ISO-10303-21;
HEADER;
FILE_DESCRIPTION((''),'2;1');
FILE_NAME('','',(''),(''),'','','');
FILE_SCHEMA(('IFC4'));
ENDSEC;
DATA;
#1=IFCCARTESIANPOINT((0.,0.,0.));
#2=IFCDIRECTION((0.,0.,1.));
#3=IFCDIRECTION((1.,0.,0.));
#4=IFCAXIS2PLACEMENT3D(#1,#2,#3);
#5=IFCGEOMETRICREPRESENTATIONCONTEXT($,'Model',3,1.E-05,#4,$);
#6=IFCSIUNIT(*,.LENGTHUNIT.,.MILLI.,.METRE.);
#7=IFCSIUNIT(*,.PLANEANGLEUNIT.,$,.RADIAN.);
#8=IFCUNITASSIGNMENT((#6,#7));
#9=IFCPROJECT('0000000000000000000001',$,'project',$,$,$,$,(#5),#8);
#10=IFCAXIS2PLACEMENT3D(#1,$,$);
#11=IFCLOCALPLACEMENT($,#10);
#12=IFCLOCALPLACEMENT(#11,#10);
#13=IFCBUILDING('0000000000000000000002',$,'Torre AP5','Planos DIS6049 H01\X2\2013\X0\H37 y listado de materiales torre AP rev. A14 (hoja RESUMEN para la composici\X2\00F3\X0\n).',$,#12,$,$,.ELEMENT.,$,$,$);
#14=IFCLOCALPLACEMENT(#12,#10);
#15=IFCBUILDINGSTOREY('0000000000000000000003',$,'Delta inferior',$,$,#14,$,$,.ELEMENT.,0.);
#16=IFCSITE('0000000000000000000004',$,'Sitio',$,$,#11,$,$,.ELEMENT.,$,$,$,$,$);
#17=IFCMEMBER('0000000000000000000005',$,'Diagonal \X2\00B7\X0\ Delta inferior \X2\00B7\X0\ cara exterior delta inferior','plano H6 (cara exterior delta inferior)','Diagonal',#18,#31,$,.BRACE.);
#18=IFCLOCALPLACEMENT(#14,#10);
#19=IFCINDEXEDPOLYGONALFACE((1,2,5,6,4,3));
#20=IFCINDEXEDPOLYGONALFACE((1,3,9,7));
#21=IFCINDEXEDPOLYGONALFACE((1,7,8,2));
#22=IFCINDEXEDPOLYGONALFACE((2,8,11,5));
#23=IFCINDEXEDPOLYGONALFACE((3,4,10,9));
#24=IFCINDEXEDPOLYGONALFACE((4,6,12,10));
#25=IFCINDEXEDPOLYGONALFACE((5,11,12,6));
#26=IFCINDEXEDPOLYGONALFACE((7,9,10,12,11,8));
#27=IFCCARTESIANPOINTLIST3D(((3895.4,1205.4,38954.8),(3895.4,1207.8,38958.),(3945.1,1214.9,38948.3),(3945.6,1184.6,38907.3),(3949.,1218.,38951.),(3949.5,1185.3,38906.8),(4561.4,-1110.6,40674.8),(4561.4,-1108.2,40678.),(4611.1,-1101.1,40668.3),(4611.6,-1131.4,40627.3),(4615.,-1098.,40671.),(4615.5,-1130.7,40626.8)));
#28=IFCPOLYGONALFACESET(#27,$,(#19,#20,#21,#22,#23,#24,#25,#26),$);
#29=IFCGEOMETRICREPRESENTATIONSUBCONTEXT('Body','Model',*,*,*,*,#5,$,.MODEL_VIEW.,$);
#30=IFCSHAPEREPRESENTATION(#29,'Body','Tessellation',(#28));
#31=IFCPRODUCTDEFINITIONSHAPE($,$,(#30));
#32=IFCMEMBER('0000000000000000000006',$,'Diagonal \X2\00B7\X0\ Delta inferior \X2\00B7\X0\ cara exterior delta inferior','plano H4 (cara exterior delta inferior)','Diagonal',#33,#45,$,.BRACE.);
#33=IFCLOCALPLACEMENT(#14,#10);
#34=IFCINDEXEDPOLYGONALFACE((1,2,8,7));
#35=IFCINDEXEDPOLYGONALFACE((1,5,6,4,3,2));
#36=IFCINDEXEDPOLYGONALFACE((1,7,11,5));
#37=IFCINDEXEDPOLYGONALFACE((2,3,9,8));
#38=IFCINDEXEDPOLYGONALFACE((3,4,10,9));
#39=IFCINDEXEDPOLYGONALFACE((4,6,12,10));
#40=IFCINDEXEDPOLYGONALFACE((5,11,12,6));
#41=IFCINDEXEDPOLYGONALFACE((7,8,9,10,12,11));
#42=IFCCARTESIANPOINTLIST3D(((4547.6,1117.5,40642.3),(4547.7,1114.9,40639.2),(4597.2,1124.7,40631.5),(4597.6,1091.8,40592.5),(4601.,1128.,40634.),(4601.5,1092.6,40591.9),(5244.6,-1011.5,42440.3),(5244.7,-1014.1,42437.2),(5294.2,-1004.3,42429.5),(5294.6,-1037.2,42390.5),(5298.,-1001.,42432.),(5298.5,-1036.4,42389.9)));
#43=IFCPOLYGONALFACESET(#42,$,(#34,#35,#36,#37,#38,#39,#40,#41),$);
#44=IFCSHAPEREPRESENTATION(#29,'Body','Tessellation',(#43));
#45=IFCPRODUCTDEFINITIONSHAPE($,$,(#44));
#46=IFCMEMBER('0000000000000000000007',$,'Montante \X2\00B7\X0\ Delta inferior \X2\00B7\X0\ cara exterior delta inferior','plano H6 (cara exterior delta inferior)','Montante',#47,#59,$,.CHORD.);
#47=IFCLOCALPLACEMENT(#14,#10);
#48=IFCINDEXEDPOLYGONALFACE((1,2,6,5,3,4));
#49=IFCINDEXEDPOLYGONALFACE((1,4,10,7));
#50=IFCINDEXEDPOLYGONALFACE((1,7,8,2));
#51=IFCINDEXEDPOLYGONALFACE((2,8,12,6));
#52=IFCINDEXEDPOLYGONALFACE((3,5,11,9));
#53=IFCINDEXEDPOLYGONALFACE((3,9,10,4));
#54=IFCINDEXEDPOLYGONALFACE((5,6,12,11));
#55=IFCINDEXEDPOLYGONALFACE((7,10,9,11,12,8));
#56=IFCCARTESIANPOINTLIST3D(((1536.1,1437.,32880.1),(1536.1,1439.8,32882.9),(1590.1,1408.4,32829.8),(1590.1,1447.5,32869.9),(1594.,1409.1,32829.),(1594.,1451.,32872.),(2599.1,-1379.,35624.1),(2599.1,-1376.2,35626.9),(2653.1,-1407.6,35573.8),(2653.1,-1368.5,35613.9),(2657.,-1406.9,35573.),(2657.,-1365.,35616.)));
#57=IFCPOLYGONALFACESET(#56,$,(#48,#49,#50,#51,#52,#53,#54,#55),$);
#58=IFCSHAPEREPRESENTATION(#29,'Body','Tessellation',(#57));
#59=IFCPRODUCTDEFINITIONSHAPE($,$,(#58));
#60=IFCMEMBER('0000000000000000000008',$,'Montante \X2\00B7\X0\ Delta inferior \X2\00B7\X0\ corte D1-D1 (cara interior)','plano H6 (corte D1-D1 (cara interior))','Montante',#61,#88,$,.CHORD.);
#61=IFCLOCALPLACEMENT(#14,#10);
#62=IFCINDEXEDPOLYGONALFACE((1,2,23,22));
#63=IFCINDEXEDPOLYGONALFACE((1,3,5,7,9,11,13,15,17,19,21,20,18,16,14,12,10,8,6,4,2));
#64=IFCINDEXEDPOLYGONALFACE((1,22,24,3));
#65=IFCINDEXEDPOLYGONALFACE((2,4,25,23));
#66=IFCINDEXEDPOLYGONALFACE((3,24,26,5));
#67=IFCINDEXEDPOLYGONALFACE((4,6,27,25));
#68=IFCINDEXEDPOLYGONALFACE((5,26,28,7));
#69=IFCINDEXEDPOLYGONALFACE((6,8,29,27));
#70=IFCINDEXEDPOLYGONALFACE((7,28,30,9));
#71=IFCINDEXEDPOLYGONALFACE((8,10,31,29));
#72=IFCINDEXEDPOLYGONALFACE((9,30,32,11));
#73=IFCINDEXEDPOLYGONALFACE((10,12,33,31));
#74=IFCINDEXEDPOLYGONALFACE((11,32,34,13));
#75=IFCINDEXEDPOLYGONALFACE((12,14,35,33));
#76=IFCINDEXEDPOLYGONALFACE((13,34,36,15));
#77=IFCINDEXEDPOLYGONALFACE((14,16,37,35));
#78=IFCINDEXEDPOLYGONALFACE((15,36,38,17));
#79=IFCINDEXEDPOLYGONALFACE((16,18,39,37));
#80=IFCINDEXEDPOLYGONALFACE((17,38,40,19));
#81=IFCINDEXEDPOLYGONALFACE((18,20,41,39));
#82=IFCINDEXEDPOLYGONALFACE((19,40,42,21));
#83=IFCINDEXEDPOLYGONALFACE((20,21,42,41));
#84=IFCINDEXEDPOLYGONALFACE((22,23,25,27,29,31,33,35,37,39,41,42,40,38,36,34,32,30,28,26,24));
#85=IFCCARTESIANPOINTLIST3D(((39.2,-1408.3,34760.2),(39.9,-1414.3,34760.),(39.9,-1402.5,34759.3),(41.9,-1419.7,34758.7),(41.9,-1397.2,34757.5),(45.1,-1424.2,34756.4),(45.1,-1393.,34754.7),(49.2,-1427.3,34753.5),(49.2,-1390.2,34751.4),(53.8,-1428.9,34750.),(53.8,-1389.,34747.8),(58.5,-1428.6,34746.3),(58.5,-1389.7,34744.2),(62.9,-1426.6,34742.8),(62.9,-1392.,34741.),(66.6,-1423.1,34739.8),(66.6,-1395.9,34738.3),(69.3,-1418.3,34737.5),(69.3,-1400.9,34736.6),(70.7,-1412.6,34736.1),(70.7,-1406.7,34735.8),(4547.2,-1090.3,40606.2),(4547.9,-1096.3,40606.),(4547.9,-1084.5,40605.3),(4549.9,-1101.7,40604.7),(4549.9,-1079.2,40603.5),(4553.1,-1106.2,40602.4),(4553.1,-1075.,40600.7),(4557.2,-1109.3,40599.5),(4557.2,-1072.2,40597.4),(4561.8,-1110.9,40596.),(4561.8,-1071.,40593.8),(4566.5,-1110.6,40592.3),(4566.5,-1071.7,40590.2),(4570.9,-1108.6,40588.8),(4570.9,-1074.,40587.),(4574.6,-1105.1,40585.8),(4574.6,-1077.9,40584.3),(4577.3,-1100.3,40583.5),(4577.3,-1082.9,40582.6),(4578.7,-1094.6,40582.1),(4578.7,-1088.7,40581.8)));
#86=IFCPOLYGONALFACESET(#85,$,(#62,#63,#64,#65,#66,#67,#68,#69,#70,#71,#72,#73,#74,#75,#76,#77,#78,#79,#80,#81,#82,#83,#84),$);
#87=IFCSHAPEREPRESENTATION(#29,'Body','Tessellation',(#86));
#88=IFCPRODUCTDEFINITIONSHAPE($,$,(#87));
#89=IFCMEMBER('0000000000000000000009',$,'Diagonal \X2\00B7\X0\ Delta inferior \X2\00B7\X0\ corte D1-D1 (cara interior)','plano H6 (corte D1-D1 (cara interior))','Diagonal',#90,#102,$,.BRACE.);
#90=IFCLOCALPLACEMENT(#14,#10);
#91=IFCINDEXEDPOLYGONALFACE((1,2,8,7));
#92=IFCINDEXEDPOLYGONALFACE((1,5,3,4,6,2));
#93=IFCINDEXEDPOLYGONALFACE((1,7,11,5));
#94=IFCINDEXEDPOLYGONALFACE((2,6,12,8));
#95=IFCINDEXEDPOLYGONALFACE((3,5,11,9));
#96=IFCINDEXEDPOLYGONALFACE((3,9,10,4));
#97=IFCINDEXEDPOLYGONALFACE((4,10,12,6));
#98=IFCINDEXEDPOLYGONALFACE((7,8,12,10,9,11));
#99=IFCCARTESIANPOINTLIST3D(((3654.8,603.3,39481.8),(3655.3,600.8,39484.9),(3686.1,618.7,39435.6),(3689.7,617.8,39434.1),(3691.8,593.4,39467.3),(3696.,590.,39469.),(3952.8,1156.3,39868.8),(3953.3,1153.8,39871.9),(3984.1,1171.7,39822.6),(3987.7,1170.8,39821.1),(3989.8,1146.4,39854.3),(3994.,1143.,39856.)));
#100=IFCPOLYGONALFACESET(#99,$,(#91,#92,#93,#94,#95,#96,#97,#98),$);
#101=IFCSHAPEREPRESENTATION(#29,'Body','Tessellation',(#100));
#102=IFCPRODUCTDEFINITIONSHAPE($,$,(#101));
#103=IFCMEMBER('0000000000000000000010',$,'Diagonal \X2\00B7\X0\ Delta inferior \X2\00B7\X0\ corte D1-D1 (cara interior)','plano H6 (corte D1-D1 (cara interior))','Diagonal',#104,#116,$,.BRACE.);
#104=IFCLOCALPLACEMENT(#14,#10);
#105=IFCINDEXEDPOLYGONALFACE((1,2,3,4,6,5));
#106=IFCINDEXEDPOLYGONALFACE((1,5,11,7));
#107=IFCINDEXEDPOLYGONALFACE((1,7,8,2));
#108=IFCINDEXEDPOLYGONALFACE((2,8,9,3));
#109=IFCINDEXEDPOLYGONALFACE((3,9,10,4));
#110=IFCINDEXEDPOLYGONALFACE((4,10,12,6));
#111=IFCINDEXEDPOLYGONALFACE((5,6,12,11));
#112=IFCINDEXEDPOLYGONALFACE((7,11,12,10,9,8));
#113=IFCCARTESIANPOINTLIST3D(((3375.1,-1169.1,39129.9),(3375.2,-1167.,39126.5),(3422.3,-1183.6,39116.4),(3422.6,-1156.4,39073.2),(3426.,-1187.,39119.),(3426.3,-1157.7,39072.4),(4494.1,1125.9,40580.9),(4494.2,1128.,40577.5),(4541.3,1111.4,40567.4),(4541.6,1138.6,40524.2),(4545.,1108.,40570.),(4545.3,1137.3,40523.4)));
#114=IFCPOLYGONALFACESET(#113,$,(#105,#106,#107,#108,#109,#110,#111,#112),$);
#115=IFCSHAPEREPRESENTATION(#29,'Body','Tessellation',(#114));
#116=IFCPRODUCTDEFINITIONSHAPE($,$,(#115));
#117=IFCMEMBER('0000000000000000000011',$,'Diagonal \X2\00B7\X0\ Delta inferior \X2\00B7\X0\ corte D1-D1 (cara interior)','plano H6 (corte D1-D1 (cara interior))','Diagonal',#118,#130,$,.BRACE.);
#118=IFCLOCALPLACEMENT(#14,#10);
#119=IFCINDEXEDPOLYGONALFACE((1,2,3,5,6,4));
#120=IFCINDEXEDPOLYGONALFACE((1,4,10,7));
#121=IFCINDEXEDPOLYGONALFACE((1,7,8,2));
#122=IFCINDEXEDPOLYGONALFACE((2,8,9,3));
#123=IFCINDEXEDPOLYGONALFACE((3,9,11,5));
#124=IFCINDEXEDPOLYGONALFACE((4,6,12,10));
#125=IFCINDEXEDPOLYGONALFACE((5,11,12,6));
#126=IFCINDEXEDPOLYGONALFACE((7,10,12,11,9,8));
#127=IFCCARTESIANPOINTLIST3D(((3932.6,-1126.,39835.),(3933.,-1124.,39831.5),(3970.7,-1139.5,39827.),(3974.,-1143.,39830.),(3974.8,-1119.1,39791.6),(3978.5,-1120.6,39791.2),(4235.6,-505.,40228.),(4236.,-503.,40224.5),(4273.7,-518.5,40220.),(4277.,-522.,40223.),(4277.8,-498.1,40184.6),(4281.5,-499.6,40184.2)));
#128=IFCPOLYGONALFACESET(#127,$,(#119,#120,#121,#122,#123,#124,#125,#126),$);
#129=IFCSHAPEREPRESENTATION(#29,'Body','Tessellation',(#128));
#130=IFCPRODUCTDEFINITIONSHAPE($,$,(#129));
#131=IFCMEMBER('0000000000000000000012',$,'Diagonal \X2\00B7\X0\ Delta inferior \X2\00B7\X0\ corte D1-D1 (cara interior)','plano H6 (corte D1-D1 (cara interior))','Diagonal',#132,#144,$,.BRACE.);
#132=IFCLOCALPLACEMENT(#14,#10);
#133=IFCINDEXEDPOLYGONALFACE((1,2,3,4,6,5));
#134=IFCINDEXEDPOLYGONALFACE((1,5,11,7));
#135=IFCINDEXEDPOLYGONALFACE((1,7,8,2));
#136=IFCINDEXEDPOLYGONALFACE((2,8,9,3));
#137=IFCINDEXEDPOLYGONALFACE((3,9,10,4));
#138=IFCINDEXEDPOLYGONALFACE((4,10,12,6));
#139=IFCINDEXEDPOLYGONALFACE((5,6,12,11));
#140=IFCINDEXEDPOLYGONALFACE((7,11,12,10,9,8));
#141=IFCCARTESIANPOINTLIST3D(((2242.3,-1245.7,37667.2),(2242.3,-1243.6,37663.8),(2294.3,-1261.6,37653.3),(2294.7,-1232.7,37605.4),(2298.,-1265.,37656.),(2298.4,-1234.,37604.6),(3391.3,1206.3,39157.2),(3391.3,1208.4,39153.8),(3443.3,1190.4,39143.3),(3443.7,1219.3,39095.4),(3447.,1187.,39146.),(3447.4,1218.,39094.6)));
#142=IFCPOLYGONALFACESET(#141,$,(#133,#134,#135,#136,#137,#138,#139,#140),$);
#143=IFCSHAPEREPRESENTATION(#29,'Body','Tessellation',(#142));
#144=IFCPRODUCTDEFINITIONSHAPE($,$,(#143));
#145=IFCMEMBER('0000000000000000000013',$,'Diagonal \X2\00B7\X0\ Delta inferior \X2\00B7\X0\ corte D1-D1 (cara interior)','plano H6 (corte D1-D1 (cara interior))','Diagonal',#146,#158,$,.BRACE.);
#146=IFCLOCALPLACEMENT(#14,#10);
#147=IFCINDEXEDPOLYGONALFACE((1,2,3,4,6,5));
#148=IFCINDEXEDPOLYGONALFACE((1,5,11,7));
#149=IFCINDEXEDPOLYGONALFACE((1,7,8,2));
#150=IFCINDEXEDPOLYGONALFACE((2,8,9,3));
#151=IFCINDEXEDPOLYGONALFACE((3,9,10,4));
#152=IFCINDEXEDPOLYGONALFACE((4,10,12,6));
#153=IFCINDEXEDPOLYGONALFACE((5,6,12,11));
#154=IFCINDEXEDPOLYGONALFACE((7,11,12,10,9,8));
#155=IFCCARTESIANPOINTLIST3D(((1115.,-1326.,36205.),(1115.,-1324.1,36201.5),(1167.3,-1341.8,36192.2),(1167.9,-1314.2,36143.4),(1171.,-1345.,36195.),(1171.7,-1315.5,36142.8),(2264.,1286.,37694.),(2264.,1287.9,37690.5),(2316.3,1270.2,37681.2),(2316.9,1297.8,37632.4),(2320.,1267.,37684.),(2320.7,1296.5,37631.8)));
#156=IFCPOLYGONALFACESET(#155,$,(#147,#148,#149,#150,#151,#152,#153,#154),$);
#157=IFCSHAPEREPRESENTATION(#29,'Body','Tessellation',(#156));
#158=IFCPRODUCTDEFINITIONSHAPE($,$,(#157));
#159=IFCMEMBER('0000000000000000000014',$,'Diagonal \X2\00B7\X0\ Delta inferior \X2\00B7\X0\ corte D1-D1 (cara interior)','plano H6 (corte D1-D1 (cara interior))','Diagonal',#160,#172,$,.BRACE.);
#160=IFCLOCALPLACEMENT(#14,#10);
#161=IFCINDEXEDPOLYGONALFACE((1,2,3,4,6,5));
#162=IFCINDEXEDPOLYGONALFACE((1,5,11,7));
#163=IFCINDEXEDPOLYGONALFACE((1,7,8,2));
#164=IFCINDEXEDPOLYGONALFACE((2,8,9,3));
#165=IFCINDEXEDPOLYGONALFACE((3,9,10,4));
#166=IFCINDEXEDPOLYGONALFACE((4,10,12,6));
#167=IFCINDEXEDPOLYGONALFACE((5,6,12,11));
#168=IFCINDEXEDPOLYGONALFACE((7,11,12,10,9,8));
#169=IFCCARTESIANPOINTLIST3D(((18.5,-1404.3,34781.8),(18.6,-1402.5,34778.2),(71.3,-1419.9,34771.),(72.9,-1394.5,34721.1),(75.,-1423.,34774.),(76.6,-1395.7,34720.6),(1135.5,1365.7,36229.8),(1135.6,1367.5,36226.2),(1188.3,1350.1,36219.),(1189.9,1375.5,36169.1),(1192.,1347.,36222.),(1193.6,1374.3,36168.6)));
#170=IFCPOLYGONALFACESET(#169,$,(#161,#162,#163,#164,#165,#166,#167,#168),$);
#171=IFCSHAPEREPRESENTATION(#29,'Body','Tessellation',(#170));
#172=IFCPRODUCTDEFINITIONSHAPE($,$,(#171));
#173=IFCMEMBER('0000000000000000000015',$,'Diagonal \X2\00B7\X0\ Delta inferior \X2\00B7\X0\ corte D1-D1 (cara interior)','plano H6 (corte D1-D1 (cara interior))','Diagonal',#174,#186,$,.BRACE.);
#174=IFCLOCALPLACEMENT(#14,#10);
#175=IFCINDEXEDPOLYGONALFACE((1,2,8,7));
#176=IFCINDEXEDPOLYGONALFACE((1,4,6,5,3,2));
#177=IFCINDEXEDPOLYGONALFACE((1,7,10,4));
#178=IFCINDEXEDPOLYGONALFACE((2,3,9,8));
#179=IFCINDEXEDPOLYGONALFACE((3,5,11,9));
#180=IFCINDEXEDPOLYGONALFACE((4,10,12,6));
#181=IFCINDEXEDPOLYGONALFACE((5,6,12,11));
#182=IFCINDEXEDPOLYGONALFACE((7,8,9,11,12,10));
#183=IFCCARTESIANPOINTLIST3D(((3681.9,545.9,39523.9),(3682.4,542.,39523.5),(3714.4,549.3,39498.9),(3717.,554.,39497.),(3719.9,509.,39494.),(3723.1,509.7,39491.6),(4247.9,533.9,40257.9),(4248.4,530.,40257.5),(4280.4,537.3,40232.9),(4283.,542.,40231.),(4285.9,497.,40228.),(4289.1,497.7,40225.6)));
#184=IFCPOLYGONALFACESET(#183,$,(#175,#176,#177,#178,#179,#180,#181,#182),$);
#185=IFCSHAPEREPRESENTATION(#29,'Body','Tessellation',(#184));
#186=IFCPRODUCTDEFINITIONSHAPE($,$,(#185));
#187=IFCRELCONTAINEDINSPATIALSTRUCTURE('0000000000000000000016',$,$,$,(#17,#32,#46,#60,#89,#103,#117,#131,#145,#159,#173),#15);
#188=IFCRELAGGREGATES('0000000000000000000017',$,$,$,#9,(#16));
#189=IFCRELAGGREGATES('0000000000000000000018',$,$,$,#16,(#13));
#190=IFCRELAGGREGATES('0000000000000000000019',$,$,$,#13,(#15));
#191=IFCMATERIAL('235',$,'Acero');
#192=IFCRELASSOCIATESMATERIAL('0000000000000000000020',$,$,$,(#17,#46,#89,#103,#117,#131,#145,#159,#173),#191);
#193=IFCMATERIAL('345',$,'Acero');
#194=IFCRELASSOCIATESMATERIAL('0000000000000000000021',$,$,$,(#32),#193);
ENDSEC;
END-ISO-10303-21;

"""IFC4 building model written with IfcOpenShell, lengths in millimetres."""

from ifc_helpers import new_model, si_unit, frame, frame_2d, origin, origin_with_axes, place, context, subcontext, project, spatial, circle, l_section, extrude, material, element, save


model = new_model("IFC4")

# Units and contexts
model_context = context("Model", 3, precision=1e-05, world=origin_with_axes())
body_context = subcontext(model_context, "Body", "Model", "MODEL_VIEW")
ifc_project = project(units=[si_unit("LENGTHUNIT", "METRE", prefix="MILLI"), si_unit("PLANEANGLEUNIT", "RADIAN")], contexts=[model_context])

# Site, building, storey
site_placement = place(None, origin())
site = spatial("IfcSite", under=ifc_project, at=site_placement, Name="Sitio", CompositionType="ELEMENT")
building_placement = place(site_placement, origin())
building = spatial("IfcBuilding", under=site, at=building_placement, Name="Torre AP5", Description="Planos DIS6049 H01–H37 y listado de materiales torre AP rev. A14 (hoja RESUMEN para la composición).", CompositionType="ELEMENT")
storey_placement = place(building_placement, origin())
storey = spatial("IfcBuildingStorey", under=building, at=storey_placement, Name="Delta inferior", CompositionType="ELEMENT", Elevation=0.0)

# Members
ifc_material_1 = material(Name="235", Category="Acero")
ifc_material_2 = material(Name="345", Category="Acero")
member_1_placement = place(storey_placement, frame((3949.0, 1218.0, 38951.0), z_axis=(0.224946, -0.782244, 0.580941), x_axis=(-0.974336, -0.185683, 0.127247)))
element("IfcMember", 1, at=member_1_placement, inside=storey, material=ifc_material_1, Name="Diagonal · Delta inferior · cara exterior delta inferior", Description="plano H6 (cara exterior delta inferior)", ObjectType="Diagonal", PredefinedType="BRACE", context=body_context, shape_type="SweptSolid", body=[
    extrude(l_section(Depth=55.0, Width=55.0, Thickness=4.0, at=frame_2d((27.5, 27.5))), None, (0.0, 0.0, 1.0), 2960.7),
])
member_2_placement = place(storey_placement, frame((4601.0, 1128.0, 40634.0), z_axis=(0.242646, -0.741166, 0.625936), x_axis=(-0.97008, -0.190866, 0.150051)))
element("IfcMember", 2, at=member_2_placement, inside=storey, material=ifc_material_2, Name="Diagonal · Delta inferior · cara exterior delta inferior", Description="plano H4 (cara exterior delta inferior)", ObjectType="Diagonal", PredefinedType="BRACE", context=body_context, shape_type="SweptSolid", body=[
    extrude(l_section(Depth=55.0, Width=55.0, Thickness=4.0, at=frame_2d((27.5, 27.5))), None, (0.0, 0.0, 1.0), 2872.5),
])
member_3_placement = place(storey_placement, frame((1594.0, 1451.0, 32872.0), z_axis=(0.260987, -0.691382, 0.673704), x_axis=(-0.965342, -0.18692, 0.18214)))
element("IfcMember", 3, at=member_3_placement, inside=storey, material=ifc_material_1, Name="Montante · Delta inferior · cara exterior delta inferior", Description="plano H6 (cara exterior delta inferior)", ObjectType="Montante", PredefinedType="CHORD", context=body_context, shape_type="SweptSolid", body=[
    extrude(l_section(Depth=60.0, Width=60.0, Thickness=4.0, at=frame_2d((30.0, 30.0))), None, (0.0, 0.0, 1.0), 4073.0),
])
member_4_placement = place(storey_placement, frame((4563.0, -1091.0, 40594.0), z_axis=(-0.610087, -0.043036, -0.791165), x_axis=(-0.792334, 0.033137, 0.609187)))
element("IfcMember", 4, at=member_4_placement, inside=storey, Name="Montante · Delta inferior · corte D1-D1 (cara interior)", Description="plano H6 (corte D1-D1 (cara interior))", ObjectType="Montante", PredefinedType="CHORD", context=body_context, shape_type="SweptSolid", body=[
    extrude(circle(Radius=20.0), None, (0.0, 0.0, 1.0), 7389.1),
])
member_5_placement = place(storey_placement, frame((3994.0, 1143.0, 39856.0), z_axis=(-0.403891, -0.749503, -0.524516), x_axis=(-0.904178, 0.239916, 0.353414)))
element("IfcMember", 5, at=member_5_placement, inside=storey, material=ifc_material_1, Name="Diagonal · Delta inferior · corte D1-D1 (cara interior)", Description="plano H6 (corte D1-D1 (cara interior))", ObjectType="Diagonal", PredefinedType="BRACE", context=body_context, shape_type="SweptSolid", body=[
    extrude(l_section(Depth=45.0, Width=45.0, Thickness=4.0, at=frame_2d((22.5, 22.5))), None, (0.0, 0.0, 1.0), 737.8),
])
member_6_placement = place(storey_placement, frame((4545.0, 1108.0, 40570.0), z_axis=(-0.381032, -0.781472, -0.494081), x_axis=(-0.924547, 0.325107, 0.198793)))
element("IfcMember", 6, at=member_6_placement, inside=storey, material=ifc_material_1, Name="Diagonal · Delta inferior · corte D1-D1 (cara interior)", Description="plano H6 (corte D1-D1 (cara interior))", ObjectType="Diagonal", PredefinedType="BRACE", context=body_context, shape_type="SweptSolid", body=[
    extrude(l_section(Depth=55.0, Width=55.0, Thickness=4.0, at=frame_2d((27.5, 27.5))), None, (0.0, 0.0, 1.0), 2936.8),
])
member_7_placement = place(storey_placement, frame((4277.0, -522.0, 40223.0), z_axis=(-0.38117, -0.78121, -0.494389), x_axis=(-0.919056, 0.378167, 0.111023)))
element("IfcMember", 7, at=member_7_placement, inside=storey, material=ifc_material_1, Name="Diagonal · Delta inferior · corte D1-D1 (cara interior)", Description="plano H6 (corte D1-D1 (cara interior))", ObjectType="Diagonal", PredefinedType="BRACE", context=body_context, shape_type="SweptSolid", body=[
    extrude(l_section(Depth=45.0, Width=45.0, Thickness=4.0, at=frame_2d((22.5, 22.5))), None, (0.0, 0.0, 1.0), 794.9),
])
member_8_placement = place(storey_placement, frame((3447.0, 1187.0, 39146.0), z_axis=(-0.371757, -0.79334, -0.482087), x_axis=(-0.928304, 0.321616, 0.18659)))
element("IfcMember", 8, at=member_8_placement, inside=storey, material=ifc_material_1, Name="Diagonal · Delta inferior · corte D1-D1 (cara interior)", Description="plano H6 (corte D1-D1 (cara interior))", ObjectType="Diagonal", PredefinedType="BRACE", context=body_context, shape_type="SweptSolid", body=[
    extrude(l_section(Depth=60.0, Width=60.0, Thickness=4.0, at=frame_2d((30.0, 30.0))), None, (0.0, 0.0, 1.0), 3090.7),
])
member_9_placement = place(storey_placement, frame((2320.0, 1267.0, 37684.0), z_axis=(-0.356979, -0.811514, -0.462613), x_axis=(-0.934048, 0.315929, 0.166565)))
element("IfcMember", 9, at=member_9_placement, inside=storey, material=ifc_material_1, Name="Diagonal · Delta inferior · corte D1-D1 (cara interior)", Description="plano H6 (corte D1-D1 (cara interior))", ObjectType="Diagonal", PredefinedType="BRACE", context=body_context, shape_type="SweptSolid", body=[
    extrude(l_section(Depth=60.0, Width=60.0, Thickness=4.0, at=frame_2d((30.0, 30.0))), None, (0.0, 0.0, 1.0), 3218.7),
])
member_10_placement = place(storey_placement, frame((1192.0, 1347.0, 36222.0), z_axis=(-0.336524, -0.834531, -0.436246), x_axis=(-0.94128, 0.311519, 0.130181)))
element("IfcMember", 10, at=member_10_placement, inside=storey, material=ifc_material_1, Name="Diagonal · Delta inferior · corte D1-D1 (cara interior)", Description="plano H6 (corte D1-D1 (cara interior))", ObjectType="Diagonal", PredefinedType="BRACE", context=body_context, shape_type="SweptSolid", body=[
    extrude(l_section(Depth=60.0, Width=60.0, Thickness=4.0, at=frame_2d((30.0, 30.0))), None, (0.0, 0.0, 1.0), 3319.2),
])
member_11_placement = place(storey_placement, frame((3717.0, 554.0, 39497.0), z_axis=(0.610598, -0.012946, 0.791835), x_axis=(-0.780393, -0.179966, 0.598832)))
element("IfcMember", 11, at=member_11_placement, inside=storey, material=ifc_material_1, Name="Diagonal · Delta inferior · corte D1-D1 (cara interior)", Description="plano H6 (corte D1-D1 (cara interior))", ObjectType="Diagonal", PredefinedType="BRACE", context=body_context, shape_type="SweptSolid", body=[
    extrude(l_section(Depth=45.0, Width=45.0, Thickness=4.0, at=frame_2d((22.5, 22.5))), None, (0.0, 0.0, 1.0), 927.0),
])

save(model, "model.ifc")
